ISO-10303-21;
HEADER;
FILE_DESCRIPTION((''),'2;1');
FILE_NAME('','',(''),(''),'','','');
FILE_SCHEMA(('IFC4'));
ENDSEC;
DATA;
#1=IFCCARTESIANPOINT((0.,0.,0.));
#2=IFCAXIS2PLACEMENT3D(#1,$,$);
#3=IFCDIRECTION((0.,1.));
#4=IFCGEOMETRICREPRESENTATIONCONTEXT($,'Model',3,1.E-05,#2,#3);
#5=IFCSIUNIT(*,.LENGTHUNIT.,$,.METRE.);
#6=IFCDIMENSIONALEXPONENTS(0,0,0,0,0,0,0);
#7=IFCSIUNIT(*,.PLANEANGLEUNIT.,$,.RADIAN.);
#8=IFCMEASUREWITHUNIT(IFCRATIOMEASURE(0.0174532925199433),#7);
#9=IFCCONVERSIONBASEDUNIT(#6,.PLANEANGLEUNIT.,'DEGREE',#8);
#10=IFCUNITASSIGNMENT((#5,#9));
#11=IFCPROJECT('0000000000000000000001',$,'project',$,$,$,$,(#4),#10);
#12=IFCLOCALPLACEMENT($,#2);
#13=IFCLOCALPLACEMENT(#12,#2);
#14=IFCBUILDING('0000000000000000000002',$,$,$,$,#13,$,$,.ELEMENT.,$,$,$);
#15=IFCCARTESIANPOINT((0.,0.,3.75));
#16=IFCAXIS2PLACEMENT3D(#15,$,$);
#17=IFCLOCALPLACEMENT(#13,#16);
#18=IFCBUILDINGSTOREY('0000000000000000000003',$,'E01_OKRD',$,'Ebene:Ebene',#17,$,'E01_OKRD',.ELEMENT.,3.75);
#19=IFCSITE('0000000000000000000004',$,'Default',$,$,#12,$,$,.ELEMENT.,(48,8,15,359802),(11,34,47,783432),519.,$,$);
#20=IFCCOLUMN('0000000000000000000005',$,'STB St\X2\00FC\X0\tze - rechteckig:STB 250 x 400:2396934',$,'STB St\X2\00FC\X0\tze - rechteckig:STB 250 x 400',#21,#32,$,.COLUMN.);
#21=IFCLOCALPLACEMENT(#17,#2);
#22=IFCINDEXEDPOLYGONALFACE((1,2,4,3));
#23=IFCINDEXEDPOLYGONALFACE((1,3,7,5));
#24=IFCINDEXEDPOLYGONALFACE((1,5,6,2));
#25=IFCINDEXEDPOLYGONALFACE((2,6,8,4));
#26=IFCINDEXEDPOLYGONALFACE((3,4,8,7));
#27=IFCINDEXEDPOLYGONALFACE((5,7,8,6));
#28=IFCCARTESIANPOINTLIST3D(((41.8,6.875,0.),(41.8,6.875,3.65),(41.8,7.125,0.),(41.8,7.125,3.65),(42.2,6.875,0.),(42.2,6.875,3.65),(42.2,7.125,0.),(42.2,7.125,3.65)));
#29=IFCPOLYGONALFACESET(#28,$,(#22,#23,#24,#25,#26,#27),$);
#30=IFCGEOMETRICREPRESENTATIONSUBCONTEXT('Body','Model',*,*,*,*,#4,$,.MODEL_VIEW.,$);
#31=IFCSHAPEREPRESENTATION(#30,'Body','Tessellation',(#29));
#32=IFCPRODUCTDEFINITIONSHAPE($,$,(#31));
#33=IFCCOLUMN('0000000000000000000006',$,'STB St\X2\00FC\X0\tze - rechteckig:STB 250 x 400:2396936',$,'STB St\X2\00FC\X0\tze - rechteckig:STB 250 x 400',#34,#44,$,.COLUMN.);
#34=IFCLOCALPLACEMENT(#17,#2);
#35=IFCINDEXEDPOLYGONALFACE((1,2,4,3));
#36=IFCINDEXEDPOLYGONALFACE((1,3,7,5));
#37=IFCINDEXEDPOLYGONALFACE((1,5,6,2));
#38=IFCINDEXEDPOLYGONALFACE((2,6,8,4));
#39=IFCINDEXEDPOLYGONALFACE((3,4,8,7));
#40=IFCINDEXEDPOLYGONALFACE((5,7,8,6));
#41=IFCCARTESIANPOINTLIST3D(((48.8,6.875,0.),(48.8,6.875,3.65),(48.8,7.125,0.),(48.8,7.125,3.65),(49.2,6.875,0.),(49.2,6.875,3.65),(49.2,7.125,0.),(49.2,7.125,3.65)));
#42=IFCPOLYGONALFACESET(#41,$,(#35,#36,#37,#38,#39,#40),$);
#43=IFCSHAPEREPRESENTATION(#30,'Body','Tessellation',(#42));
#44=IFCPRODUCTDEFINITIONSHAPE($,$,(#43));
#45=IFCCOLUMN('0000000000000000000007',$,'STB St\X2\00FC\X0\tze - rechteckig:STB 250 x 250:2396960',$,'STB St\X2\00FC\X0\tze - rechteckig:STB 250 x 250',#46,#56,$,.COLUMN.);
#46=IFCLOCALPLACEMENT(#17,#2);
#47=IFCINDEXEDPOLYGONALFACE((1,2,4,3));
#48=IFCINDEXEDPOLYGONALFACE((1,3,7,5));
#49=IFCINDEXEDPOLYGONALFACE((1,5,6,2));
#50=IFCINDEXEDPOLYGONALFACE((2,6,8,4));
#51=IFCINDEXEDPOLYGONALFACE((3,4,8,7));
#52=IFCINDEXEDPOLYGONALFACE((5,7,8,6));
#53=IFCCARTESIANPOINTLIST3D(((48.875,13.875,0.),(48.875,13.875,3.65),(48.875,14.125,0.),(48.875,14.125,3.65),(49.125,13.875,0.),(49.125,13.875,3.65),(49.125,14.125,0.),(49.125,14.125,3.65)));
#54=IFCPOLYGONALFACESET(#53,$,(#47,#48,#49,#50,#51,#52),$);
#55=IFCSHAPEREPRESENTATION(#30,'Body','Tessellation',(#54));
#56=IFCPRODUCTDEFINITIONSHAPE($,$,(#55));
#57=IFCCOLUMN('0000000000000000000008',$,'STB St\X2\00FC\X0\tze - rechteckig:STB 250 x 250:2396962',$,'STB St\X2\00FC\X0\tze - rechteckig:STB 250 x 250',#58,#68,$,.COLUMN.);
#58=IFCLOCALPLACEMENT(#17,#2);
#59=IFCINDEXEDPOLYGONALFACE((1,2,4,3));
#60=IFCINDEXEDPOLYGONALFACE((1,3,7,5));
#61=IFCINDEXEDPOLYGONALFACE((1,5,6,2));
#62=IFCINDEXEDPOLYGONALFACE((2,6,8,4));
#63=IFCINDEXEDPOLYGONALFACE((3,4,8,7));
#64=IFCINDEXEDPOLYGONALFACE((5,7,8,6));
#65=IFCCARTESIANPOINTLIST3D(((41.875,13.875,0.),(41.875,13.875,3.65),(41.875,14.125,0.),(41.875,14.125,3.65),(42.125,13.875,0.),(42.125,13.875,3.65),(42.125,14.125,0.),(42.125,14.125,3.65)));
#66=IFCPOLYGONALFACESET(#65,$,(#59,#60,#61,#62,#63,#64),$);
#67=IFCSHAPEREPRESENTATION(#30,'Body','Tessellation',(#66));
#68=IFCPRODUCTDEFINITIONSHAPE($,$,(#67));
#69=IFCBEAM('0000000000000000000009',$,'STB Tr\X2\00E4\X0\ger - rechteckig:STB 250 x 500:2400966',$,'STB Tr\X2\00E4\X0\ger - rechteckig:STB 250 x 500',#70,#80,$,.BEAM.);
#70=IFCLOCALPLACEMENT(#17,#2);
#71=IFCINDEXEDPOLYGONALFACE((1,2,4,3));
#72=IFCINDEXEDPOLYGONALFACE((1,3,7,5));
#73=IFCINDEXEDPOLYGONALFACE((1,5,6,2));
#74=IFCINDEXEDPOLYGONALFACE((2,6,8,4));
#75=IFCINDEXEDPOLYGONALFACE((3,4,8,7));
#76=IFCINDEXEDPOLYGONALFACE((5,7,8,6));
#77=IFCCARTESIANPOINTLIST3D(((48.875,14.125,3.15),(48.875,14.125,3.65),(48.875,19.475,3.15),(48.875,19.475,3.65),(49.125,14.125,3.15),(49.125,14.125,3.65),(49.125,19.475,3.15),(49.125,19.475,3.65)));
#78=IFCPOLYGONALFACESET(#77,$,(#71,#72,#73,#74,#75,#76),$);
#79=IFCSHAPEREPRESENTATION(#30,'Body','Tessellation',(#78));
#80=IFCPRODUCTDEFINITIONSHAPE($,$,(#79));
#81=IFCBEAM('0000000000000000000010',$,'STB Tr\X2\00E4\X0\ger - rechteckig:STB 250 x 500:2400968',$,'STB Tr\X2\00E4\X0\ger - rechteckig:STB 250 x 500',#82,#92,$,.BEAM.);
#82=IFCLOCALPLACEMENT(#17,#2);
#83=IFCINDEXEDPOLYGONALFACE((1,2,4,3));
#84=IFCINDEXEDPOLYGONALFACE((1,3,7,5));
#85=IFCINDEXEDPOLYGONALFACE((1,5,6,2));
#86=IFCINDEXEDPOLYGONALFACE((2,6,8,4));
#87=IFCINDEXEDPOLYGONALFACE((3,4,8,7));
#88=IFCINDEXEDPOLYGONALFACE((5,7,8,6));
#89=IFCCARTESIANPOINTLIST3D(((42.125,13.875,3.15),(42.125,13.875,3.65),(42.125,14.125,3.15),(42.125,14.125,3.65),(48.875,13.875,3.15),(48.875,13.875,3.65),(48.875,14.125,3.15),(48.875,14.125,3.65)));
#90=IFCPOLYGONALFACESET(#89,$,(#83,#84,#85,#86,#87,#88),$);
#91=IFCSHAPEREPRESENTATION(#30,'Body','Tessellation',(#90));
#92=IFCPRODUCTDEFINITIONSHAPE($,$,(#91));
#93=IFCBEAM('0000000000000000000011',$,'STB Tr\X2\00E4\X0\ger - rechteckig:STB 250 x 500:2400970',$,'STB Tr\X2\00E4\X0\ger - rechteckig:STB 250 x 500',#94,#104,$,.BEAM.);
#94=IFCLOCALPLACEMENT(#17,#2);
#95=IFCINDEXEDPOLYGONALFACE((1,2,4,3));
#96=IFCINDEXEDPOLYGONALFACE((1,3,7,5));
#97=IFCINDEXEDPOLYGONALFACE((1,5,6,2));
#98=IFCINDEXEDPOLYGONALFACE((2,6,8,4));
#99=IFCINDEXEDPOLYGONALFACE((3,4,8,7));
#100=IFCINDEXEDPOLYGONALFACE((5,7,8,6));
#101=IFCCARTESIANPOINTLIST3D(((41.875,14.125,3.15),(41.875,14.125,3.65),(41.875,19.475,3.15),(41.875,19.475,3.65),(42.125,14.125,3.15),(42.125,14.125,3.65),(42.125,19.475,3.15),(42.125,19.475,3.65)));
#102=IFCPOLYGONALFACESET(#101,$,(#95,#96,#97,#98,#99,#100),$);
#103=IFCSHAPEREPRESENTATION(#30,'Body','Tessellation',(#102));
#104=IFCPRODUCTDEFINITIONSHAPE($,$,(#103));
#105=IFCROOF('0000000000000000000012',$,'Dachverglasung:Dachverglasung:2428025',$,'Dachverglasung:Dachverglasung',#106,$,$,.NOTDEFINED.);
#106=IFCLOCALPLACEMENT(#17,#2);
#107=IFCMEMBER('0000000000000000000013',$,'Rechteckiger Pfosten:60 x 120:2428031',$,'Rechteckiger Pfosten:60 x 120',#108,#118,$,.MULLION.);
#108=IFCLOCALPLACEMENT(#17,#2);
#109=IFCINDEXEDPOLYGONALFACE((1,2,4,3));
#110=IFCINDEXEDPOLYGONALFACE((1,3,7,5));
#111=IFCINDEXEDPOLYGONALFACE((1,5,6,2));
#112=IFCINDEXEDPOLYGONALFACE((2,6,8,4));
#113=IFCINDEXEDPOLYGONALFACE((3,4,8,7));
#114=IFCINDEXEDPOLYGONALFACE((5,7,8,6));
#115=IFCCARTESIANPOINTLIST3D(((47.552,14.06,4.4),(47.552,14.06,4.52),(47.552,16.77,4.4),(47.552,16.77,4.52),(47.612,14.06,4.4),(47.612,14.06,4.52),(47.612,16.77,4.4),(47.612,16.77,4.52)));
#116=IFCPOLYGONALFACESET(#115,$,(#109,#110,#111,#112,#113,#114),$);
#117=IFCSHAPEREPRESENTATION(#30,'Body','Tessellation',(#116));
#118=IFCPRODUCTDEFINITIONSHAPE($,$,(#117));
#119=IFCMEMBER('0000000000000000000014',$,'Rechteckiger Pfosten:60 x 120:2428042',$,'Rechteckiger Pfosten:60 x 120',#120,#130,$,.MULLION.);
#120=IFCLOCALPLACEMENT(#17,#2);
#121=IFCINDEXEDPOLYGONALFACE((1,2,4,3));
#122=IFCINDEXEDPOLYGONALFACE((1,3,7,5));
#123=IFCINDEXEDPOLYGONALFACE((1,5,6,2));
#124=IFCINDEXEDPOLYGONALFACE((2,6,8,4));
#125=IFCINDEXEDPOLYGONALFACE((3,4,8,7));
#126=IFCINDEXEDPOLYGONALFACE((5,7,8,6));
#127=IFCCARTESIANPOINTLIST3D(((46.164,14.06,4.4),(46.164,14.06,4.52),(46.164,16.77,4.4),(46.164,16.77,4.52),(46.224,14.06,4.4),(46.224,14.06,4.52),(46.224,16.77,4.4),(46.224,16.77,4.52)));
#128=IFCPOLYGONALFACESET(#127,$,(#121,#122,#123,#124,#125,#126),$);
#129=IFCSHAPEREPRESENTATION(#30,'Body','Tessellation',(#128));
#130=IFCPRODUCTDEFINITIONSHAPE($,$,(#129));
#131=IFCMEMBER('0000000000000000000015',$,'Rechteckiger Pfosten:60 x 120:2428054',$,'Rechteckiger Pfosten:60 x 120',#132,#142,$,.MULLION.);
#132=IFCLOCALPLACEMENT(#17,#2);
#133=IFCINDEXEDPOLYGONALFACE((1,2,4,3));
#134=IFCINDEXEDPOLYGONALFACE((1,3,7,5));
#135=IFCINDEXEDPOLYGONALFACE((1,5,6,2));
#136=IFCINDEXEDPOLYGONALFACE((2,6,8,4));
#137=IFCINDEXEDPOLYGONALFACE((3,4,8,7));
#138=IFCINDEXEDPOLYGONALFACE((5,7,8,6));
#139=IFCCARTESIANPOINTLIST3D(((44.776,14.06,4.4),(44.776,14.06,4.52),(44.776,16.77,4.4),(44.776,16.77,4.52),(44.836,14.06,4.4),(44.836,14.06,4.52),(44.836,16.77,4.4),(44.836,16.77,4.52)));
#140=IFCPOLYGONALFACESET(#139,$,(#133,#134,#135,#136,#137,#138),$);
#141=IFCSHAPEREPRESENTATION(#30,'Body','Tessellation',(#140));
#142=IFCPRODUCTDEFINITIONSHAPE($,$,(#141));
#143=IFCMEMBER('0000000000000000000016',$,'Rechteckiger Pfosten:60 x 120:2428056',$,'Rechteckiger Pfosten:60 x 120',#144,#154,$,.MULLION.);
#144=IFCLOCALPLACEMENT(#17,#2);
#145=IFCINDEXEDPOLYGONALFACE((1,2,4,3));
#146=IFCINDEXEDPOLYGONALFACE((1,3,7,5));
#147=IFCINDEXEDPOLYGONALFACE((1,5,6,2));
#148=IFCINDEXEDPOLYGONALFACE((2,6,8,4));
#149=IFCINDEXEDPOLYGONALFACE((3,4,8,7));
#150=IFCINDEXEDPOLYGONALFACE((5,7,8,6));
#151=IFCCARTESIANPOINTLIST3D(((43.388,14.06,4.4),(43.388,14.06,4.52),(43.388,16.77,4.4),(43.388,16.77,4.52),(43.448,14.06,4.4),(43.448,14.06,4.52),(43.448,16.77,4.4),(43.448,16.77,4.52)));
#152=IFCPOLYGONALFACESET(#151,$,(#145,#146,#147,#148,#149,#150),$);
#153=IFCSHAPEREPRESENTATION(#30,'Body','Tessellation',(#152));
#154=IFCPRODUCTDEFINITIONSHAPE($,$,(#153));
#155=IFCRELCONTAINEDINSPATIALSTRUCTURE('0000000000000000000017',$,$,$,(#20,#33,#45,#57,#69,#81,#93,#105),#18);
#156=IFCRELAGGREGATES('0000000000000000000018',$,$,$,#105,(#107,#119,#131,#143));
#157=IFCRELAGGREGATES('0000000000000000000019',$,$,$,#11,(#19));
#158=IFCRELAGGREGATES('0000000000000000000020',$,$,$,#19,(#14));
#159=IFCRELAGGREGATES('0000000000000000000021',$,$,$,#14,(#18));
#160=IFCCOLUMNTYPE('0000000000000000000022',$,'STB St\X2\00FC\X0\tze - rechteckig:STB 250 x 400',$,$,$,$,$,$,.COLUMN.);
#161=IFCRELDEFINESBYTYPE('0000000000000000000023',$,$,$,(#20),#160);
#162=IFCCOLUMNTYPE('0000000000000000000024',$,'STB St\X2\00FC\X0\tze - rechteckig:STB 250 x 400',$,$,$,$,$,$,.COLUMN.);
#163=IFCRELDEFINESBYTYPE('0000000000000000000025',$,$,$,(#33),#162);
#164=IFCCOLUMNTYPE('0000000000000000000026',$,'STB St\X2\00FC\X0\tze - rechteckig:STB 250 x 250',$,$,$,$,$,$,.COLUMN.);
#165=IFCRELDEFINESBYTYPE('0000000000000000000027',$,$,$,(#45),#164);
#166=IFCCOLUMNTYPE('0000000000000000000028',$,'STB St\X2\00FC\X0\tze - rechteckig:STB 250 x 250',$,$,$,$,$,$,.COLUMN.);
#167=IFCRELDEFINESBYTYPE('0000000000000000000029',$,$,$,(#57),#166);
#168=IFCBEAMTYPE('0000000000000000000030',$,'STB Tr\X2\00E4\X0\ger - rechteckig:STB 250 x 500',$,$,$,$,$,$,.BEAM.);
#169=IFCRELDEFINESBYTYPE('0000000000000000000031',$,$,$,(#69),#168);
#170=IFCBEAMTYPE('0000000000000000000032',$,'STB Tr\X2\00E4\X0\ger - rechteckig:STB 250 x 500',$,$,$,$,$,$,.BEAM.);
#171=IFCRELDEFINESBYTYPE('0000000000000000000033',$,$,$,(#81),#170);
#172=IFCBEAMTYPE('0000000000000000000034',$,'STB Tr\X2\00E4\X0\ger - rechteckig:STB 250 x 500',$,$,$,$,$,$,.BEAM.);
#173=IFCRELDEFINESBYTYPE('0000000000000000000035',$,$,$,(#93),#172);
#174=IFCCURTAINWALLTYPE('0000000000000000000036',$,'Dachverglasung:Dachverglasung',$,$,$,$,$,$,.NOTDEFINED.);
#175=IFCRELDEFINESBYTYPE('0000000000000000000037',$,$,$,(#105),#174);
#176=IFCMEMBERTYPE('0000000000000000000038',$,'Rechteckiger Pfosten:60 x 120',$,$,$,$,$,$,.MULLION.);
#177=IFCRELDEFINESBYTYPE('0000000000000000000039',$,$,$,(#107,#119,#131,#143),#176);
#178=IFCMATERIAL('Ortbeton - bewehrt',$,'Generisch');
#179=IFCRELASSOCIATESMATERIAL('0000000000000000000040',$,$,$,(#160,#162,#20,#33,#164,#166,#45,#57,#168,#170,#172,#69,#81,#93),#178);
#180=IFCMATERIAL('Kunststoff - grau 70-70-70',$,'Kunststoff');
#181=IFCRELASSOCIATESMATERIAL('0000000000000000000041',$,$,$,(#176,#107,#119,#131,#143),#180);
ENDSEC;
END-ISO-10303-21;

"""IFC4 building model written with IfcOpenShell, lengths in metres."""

from ifc_helpers import new_model, entity, si_unit, converted_unit, direction, frame, frame_2d, origin, origin_2d_with_axis, place, context, subcontext, project, spatial, rectangle, extrude, source, transform, mapped, material, material_profile, profile_set, profile_usage, type_object, type_shapes, element, aggregate, save


model = new_model("IFC4")

# Units and contexts
model_context = context("Model", 3, precision=1e-05, world=origin(), true_north=direction((0.0, 1.0)))
body_context = subcontext(model_context, "Body", "Model", "MODEL_VIEW")
ifc_project = project(units=[si_unit("LENGTHUNIT", "METRE"), converted_unit("PLANEANGLEUNIT", "DEGREE", entity("IfcRatioMeasure", 0.0174532925199433), si_unit("PLANEANGLEUNIT", "RADIAN"), dimensions=[0, 0, 0, 0, 0, 0, 0])], contexts=[model_context])

# Site, building, storey
site_placement = place(None, frame((0.0, 0.0, 0.0)))
site = spatial("IfcSite", under=ifc_project, at=site_placement, Name="Default", CompositionType="ELEMENT", RefLatitude=(48, 8, 15, 359802), RefLongitude=(11, 34, 47, 783432), RefElevation=519.0)
building_placement = place(site_placement, origin())
building = spatial("IfcBuilding", under=site, at=building_placement, CompositionType="ELEMENT")
storey_placement = place(building_placement, frame((0.0, 0.0, 3.75)))
storey = spatial("IfcBuildingStorey", under=building, at=storey_placement, Name="E01_OKRD", ObjectType="Ebene:Ebene", LongName="E01_OKRD", CompositionType="ELEMENT", Elevation=3.75)

# Columns
ifc_material_1 = material(Name="Ortbeton - bewehrt", Category="Generisch")
ifc_material_profile_1 = material_profile(ifc_material_1, rectangle(XDim=0.4, YDim=0.25, at=frame_2d((0.0, 0.0), x_axis=(1.0, 0.0))), Name="STB 250 x 400")
ifc_profile_set_1 = profile_set([ifc_material_profile_1], Name="STB 250 x 400")
ifc_profile_usage_1 = profile_usage(ifc_profile_set_1)
column_type_1 = type_object("IfcColumnType", Name="STB Stütze - rechteckig:STB 250 x 400", PredefinedType="COLUMN", material=ifc_profile_set_1)
shared_shape_1 = source(origin(), body_context, "Body", "SweptSolid", [
    extrude(rectangle(XDim=0.4, YDim=0.25, at=frame_2d((0.0, 0.0), x_axis=(1.0, 0.0))), frame((0.2, 0.125, 0.0), z_axis=(0.0, 0.0, 1.0), x_axis=(-1.0, 0.0, 0.0)), (0.0, 0.0, 1.0), 3.65),
])
type_shapes(column_type_1, [shared_shape_1])
column_1_placement = place(storey_placement, frame((41.8, 6.875, 0.0)))
element("IfcColumn", 1, at=column_1_placement, inside=storey, type_object=column_type_1, material=ifc_profile_usage_1, Name="STB Stütze - rechteckig:STB 250 x 400:2396934", ObjectType="STB Stütze - rechteckig:STB 250 x 400", PredefinedType="COLUMN", context=body_context, shape_type="MappedRepresentation", body=[
    mapped(shared_shape_1, transform((0.0, 0.0, 0.0), scale=1.0)),
])
ifc_profile_usage_2 = profile_usage(ifc_profile_set_1)
column_type_2 = type_object("IfcColumnType", Name="STB Stütze - rechteckig:STB 250 x 400", PredefinedType="COLUMN", material=ifc_profile_set_1)
shared_shape_2 = source(origin(), body_context, "Body", "SweptSolid", [
    extrude(rectangle(XDim=0.4, YDim=0.25, at=frame_2d((0.0, 0.0), x_axis=(1.0, 0.0))), frame((0.2, 0.125, 0.0), z_axis=(0.0, 0.0, 1.0), x_axis=(-1.0, 0.0, 0.0)), (0.0, 0.0, 1.0), 3.65),
])
type_shapes(column_type_2, [shared_shape_2])
column_2_placement = place(storey_placement, frame((48.8, 6.875, 0.0)))
element("IfcColumn", 2, at=column_2_placement, inside=storey, type_object=column_type_2, material=ifc_profile_usage_2, Name="STB Stütze - rechteckig:STB 250 x 400:2396936", ObjectType="STB Stütze - rechteckig:STB 250 x 400", PredefinedType="COLUMN", context=body_context, shape_type="MappedRepresentation", body=[
    mapped(shared_shape_2, transform((0.0, 0.0, 0.0), scale=1.0)),
])
ifc_material_profile_2 = material_profile(ifc_material_1, rectangle(XDim=0.25, YDim=0.25, at=origin_2d_with_axis()), Name="STB 250 x 250")
ifc_profile_set_2 = profile_set([ifc_material_profile_2], Name="STB 250 x 250")
ifc_profile_usage_3 = profile_usage(ifc_profile_set_2)
column_type_3 = type_object("IfcColumnType", Name="STB Stütze - rechteckig:STB 250 x 250", PredefinedType="COLUMN", material=ifc_profile_set_2)
shared_shape_3 = source(origin(), body_context, "Body", "SweptSolid", [
    extrude(rectangle(XDim=0.25, YDim=0.25, at=frame_2d((0.0, 0.0), x_axis=(1.0, 0.0))), frame((0.125, 0.125, 0.0), z_axis=(0.0, 0.0, 1.0), x_axis=(-1.0, 0.0, 0.0)), (0.0, 0.0, 1.0), 3.65),
])
type_shapes(column_type_3, [shared_shape_3])
column_3_placement = place(storey_placement, frame((48.875, 13.875, 0.0)))
element("IfcColumn", 3, at=column_3_placement, inside=storey, type_object=column_type_3, material=ifc_profile_usage_3, Name="STB Stütze - rechteckig:STB 250 x 250:2396960", ObjectType="STB Stütze - rechteckig:STB 250 x 250", PredefinedType="COLUMN", context=body_context, shape_type="MappedRepresentation", body=[
    mapped(shared_shape_3, transform((0.0, 0.0, 0.0), scale=1.0)),
])
ifc_profile_usage_4 = profile_usage(ifc_profile_set_2)
column_type_4 = type_object("IfcColumnType", Name="STB Stütze - rechteckig:STB 250 x 250", PredefinedType="COLUMN", material=ifc_profile_set_2)
shared_shape_4 = source(origin(), body_context, "Body", "SweptSolid", [
    extrude(rectangle(XDim=0.25, YDim=0.25, at=frame_2d((0.0, 0.0), x_axis=(1.0, 0.0))), frame((0.125, 0.125, 0.0), z_axis=(0.0, 0.0, 1.0), x_axis=(-1.0, 0.0, 0.0)), (0.0, 0.0, 1.0), 3.65),
])
type_shapes(column_type_4, [shared_shape_4])
column_4_placement = place(storey_placement, frame((41.875, 13.875, 0.0)))
element("IfcColumn", 4, at=column_4_placement, inside=storey, type_object=column_type_4, material=ifc_profile_usage_4, Name="STB Stütze - rechteckig:STB 250 x 250:2396962", ObjectType="STB Stütze - rechteckig:STB 250 x 250", PredefinedType="COLUMN", context=body_context, shape_type="MappedRepresentation", body=[
    mapped(shared_shape_4, transform((0.0, 0.0, 0.0), scale=1.0)),
])

# Beams
ifc_material_profile_3 = material_profile(ifc_material_1, rectangle(XDim=0.5, YDim=0.25, at=frame_2d((0.0, 0.0), x_axis=(1.0, 0.0))), Name="STB 250 x 500")
ifc_profile_set_3 = profile_set([ifc_material_profile_3], Name="STB 250 x 500")
ifc_profile_usage_5 = profile_usage(ifc_profile_set_3, cardinal=8)
beam_type_1 = type_object("IfcBeamType", Name="STB Träger - rechteckig:STB 250 x 500", PredefinedType="BEAM", material=ifc_profile_set_3)
shared_shape_5 = source(origin(), body_context, "Body", "SweptSolid", [
    extrude(rectangle(XDim=0.5, YDim=5.35, at=frame_2d((0.0, 0.0), x_axis=(0.0, 1.0))), frame((0.0, 2.675, 0.25), z_axis=(1.0, 0.0, 0.0), x_axis=(0.0, -1.0, 0.0)), (0.0, 0.0, 1.0), 0.25),
])
type_shapes(beam_type_1, [shared_shape_5])
beam_1_placement = place(storey_placement, frame((48.875, 14.125, 3.15)))
element("IfcBeam", 5, at=beam_1_placement, inside=storey, type_object=beam_type_1, material=ifc_profile_usage_5, Name="STB Träger - rechteckig:STB 250 x 500:2400966", ObjectType="STB Träger - rechteckig:STB 250 x 500", PredefinedType="BEAM", context=body_context, shape_type="MappedRepresentation", body=[
    mapped(shared_shape_5, transform((0.0, 0.0, 0.0), scale=1.0)),
])
ifc_profile_usage_6 = profile_usage(ifc_profile_set_3, cardinal=8)
beam_type_2 = type_object("IfcBeamType", Name="STB Träger - rechteckig:STB 250 x 500", PredefinedType="BEAM", material=ifc_profile_set_3)
shared_shape_6 = source(origin(), body_context, "Body", "SweptSolid", [
    extrude(rectangle(XDim=0.5, YDim=0.25, at=frame_2d((0.0, 0.0), x_axis=(1.0, 0.0))), frame((0.0, 0.125, 0.25), z_axis=(1.0, 0.0, 0.0), x_axis=(0.0, 0.0, -1.0)), (0.0, 0.0, 1.0), 6.75),
])
type_shapes(beam_type_2, [shared_shape_6])
beam_2_placement = place(storey_placement, frame((42.125, 13.875, 3.15)))
element("IfcBeam", 6, at=beam_2_placement, inside=storey, type_object=beam_type_2, material=ifc_profile_usage_6, Name="STB Träger - rechteckig:STB 250 x 500:2400968", ObjectType="STB Träger - rechteckig:STB 250 x 500", PredefinedType="BEAM", context=body_context, shape_type="MappedRepresentation", body=[
    mapped(shared_shape_6, transform((0.0, 0.0, 0.0), scale=1.0)),
])
ifc_profile_usage_7 = profile_usage(ifc_profile_set_3, cardinal=8)
beam_type_3 = type_object("IfcBeamType", Name="STB Träger - rechteckig:STB 250 x 500", PredefinedType="BEAM", material=ifc_profile_set_3)
shared_shape_7 = source(origin(), body_context, "Body", "SweptSolid", [
    extrude(rectangle(XDim=0.5, YDim=5.35, at=frame_2d((0.0, 0.0), x_axis=(0.0, 1.0))), frame((0.0, 2.675, 0.25), z_axis=(1.0, 0.0, 0.0), x_axis=(0.0, -1.0, 0.0)), (0.0, 0.0, 1.0), 0.25),
])
type_shapes(beam_type_3, [shared_shape_7])
beam_3_placement = place(storey_placement, frame((41.875, 14.125, 3.15)))
element("IfcBeam", 7, at=beam_3_placement, inside=storey, type_object=beam_type_3, material=ifc_profile_usage_7, Name="STB Träger - rechteckig:STB 250 x 500:2400970", ObjectType="STB Träger - rechteckig:STB 250 x 500", PredefinedType="BEAM", context=body_context, shape_type="MappedRepresentation", body=[
    mapped(shared_shape_7, transform((0.0, 0.0, 0.0), scale=1.0)),
])

# Roof, members
curtain_wall_type = type_object("IfcCurtainWallType", Name="Dachverglasung:Dachverglasung", PredefinedType="NOTDEFINED")
roof_1_placement = place(storey_placement, frame((0.0, 0.0, -3.75)))
roof_1 = element("IfcRoof", 8, at=roof_1_placement, inside=storey, type_object=curtain_wall_type, Name="Dachverglasung:Dachverglasung:2428025", ObjectType="Dachverglasung:Dachverglasung", PredefinedType="NOTDEFINED")
ifc_material_2 = material(Name="Kunststoff - grau 70-70-70", Category="Kunststoff")
ifc_material_profile_4 = material_profile(ifc_material_2, rectangle(XDim=0.06, YDim=0.12, at=frame_2d((0.0, 0.0), x_axis=(1.0, 0.0))), Name="60 x 120")
ifc_profile_set_4 = profile_set([ifc_material_profile_4], Name="60 x 120")
ifc_profile_usage_8 = profile_usage(ifc_profile_set_4)
member_type_1 = type_object("IfcMemberType", Name="Rechteckiger Pfosten:60 x 120", PredefinedType="MULLION", material=ifc_profile_set_4)
shared_shape_8 = source(origin(), body_context, "Body", "SweptSolid", [
    extrude(rectangle(XDim=0.06, YDim=0.12, at=frame_2d((0.0, 0.0), x_axis=(1.0, 0.0))), frame((0.0, 0.0, -2.71), z_axis=(0.0, 0.0, 1.0), x_axis=(-1.0, 0.0, 0.0)), (0.0, 0.0, 1.0), 2.71),
])
type_shapes(member_type_1, [shared_shape_8])
member_1_placement = place(storey_placement, frame((47.582, 14.06, 4.46), z_axis=(0.0, -1.0, 0.0), x_axis=(-1.0, 0.0, 0.0)))
member_1 = element("IfcMember", 9, at=member_1_placement, type_object=member_type_1, material=ifc_profile_usage_8, Name="Rechteckiger Pfosten:60 x 120:2428031", ObjectType="Rechteckiger Pfosten:60 x 120", PredefinedType="MULLION", context=body_context, shape_type="MappedRepresentation", body=[
    mapped(shared_shape_8, transform((0.0, 0.0, 0.0), scale=1.0)),
])
ifc_profile_usage_9 = profile_usage(ifc_profile_set_4)
member_2_placement = place(storey_placement, frame((46.194, 14.06, 4.46), z_axis=(0.0, -1.0, 0.0), x_axis=(-1.0, 0.0, 0.0)))
member_2 = element("IfcMember", 10, at=member_2_placement, type_object=member_type_1, material=ifc_profile_usage_9, Name="Rechteckiger Pfosten:60 x 120:2428042", ObjectType="Rechteckiger Pfosten:60 x 120", PredefinedType="MULLION", context=body_context, shape_type="MappedRepresentation", body=[
    mapped(shared_shape_8, transform((0.0, 0.0, 0.0), scale=1.0)),
])
ifc_profile_usage_10 = profile_usage(ifc_profile_set_4)
member_3_placement = place(storey_placement, frame((44.806, 14.06, 4.46), z_axis=(0.0, -1.0, 0.0), x_axis=(-1.0, 0.0, 0.0)))
member_3 = element("IfcMember", 11, at=member_3_placement, type_object=member_type_1, material=ifc_profile_usage_10, Name="Rechteckiger Pfosten:60 x 120:2428054", ObjectType="Rechteckiger Pfosten:60 x 120", PredefinedType="MULLION", context=body_context, shape_type="MappedRepresentation", body=[
    mapped(shared_shape_8, transform((0.0, 0.0, 0.0), scale=1.0)),
])
ifc_profile_usage_11 = profile_usage(ifc_profile_set_4)
member_4_placement = place(storey_placement, frame((43.418, 14.06, 4.46), z_axis=(0.0, -1.0, 0.0), x_axis=(-1.0, 0.0, 0.0)))
member_4 = element("IfcMember", 12, at=member_4_placement, type_object=member_type_1, material=ifc_profile_usage_11, Name="Rechteckiger Pfosten:60 x 120:2428056", ObjectType="Rechteckiger Pfosten:60 x 120", PredefinedType="MULLION", context=body_context, shape_type="MappedRepresentation", body=[
    mapped(shared_shape_8, transform((0.0, 0.0, 0.0), scale=1.0)),
])

aggregate(roof_1, [member_1, member_2, member_3, member_4])

save(model, "model.ifc")
